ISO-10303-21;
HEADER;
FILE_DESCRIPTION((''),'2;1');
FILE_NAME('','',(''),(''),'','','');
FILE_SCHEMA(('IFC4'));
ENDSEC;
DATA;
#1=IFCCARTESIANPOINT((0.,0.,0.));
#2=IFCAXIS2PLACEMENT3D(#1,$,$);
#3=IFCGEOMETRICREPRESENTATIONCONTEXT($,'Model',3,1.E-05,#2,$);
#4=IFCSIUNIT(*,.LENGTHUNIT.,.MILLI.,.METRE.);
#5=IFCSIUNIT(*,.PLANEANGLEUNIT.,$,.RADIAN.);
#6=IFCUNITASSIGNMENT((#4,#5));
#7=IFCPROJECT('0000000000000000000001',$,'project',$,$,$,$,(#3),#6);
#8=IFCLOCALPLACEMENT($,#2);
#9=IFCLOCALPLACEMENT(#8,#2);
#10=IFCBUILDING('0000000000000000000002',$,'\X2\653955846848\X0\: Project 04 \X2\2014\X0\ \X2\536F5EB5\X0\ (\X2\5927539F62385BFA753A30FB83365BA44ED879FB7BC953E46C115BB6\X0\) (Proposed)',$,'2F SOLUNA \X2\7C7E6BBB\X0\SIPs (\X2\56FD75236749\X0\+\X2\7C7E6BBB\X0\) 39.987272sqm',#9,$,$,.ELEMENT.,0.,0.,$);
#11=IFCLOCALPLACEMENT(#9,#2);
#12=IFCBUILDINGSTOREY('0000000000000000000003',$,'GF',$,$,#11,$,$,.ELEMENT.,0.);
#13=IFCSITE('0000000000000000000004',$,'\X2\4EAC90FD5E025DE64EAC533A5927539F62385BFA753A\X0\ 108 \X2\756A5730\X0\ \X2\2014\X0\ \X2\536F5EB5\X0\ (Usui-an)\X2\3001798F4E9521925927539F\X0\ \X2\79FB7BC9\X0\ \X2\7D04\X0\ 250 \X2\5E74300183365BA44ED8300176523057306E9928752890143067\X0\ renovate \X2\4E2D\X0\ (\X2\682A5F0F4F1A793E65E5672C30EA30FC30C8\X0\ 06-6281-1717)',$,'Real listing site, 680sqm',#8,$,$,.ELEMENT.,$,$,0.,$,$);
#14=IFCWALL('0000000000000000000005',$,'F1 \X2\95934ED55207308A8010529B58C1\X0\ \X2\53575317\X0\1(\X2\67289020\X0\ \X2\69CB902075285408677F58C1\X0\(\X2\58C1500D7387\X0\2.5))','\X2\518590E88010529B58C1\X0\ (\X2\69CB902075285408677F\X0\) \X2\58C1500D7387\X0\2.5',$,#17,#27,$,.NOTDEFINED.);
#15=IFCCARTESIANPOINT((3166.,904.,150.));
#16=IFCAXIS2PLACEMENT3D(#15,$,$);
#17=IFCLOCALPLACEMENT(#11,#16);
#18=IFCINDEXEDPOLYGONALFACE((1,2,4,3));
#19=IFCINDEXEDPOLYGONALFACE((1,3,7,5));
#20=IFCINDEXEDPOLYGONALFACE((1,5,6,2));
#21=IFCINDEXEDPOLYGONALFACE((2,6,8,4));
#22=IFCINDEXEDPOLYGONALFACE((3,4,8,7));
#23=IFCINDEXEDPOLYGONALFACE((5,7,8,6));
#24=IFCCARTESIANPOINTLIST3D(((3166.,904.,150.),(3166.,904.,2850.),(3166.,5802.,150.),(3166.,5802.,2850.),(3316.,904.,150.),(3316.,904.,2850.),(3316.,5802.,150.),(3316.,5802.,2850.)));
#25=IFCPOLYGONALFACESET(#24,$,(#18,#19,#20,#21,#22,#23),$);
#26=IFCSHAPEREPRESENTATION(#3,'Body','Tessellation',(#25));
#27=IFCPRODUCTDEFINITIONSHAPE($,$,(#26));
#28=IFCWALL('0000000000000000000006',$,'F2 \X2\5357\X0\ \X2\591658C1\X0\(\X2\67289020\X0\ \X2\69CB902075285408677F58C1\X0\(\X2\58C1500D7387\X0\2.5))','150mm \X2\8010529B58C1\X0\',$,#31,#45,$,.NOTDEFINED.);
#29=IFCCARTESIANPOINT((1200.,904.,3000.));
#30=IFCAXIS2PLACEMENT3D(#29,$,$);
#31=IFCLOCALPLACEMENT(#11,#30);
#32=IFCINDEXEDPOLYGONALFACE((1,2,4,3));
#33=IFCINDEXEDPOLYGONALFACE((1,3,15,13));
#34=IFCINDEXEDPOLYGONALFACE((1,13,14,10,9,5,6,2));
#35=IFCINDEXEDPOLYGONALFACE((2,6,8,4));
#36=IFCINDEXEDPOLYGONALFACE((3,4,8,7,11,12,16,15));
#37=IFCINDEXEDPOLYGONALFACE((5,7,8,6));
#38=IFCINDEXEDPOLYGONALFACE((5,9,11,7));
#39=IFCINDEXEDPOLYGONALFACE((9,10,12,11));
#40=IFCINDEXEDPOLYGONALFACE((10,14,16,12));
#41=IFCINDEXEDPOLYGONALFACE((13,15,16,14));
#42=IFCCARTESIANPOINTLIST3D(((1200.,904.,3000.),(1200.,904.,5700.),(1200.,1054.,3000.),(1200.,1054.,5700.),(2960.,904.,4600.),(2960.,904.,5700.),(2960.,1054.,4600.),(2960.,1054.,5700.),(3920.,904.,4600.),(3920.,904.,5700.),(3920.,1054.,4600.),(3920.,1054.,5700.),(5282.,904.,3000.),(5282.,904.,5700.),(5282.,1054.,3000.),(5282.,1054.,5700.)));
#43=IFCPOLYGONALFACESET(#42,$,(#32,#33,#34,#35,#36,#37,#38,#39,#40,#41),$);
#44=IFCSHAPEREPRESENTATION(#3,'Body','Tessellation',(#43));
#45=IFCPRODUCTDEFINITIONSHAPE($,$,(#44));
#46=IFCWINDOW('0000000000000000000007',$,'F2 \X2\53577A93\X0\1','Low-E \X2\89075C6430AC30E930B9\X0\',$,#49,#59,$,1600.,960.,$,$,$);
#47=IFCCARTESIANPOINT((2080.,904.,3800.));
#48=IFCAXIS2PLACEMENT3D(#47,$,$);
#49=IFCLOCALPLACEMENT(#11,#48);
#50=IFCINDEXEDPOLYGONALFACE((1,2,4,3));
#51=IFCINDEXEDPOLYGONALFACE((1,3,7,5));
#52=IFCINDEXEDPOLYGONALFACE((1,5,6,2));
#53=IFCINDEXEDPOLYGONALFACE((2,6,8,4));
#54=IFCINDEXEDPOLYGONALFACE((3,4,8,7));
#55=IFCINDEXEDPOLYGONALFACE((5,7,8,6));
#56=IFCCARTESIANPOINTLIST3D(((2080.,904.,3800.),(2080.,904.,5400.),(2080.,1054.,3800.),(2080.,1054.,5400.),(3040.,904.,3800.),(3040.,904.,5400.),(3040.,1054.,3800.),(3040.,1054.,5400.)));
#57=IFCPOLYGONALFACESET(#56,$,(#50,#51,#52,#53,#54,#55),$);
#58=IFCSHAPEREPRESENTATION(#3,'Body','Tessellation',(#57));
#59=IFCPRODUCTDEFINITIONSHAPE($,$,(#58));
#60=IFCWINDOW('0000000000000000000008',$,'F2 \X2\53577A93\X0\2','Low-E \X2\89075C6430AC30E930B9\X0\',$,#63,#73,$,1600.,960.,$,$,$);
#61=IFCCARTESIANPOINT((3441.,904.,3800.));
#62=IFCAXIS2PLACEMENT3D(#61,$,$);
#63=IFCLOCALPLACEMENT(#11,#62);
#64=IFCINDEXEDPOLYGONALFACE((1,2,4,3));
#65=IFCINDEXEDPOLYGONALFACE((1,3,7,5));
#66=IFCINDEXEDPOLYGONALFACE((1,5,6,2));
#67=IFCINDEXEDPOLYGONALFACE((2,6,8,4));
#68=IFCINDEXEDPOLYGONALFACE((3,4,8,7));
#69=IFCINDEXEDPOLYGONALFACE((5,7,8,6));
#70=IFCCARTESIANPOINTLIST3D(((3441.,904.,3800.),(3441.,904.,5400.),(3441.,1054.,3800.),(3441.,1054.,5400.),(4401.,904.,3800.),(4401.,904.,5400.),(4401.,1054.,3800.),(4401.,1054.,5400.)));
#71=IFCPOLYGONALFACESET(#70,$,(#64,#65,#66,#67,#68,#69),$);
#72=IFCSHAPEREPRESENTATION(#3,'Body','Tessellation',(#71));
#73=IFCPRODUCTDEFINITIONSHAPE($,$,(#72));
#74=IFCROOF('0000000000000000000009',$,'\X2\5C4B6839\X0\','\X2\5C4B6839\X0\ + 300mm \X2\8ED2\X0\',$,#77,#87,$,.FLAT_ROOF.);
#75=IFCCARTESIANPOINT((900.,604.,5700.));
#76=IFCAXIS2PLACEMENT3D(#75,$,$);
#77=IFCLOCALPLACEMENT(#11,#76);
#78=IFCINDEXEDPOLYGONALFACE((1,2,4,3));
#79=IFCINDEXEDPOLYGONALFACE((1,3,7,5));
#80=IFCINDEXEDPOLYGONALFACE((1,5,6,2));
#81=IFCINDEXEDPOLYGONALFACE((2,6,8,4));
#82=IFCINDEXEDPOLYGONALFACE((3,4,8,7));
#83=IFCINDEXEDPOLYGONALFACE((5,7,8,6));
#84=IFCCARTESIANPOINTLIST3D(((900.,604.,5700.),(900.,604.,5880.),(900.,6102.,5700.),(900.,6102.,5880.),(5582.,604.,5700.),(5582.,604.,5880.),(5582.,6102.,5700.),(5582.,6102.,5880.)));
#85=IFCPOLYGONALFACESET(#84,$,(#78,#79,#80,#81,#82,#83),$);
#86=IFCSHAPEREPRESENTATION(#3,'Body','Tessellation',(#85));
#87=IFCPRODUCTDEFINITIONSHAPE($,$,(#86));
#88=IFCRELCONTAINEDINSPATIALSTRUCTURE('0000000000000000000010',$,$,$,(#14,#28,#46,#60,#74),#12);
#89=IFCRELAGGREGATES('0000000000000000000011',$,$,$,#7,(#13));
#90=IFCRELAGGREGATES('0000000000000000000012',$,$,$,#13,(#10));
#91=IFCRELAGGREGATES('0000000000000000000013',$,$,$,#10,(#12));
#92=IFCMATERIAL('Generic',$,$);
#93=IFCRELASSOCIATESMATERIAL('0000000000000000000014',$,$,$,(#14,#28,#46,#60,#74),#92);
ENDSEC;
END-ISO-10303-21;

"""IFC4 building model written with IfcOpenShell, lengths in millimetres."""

from ifc_helpers import new_model, si_unit, frame, frame_2d, origin, place, context, project, spatial, rectangle, extrude, material, element, fill, save


model = new_model("IFC4")

# Units and contexts
model_context = context("Model", 3, precision=1e-05, world=origin())
ifc_project = project(units=[si_unit("LENGTHUNIT", "METRE", prefix="MILLI"), si_unit("PLANEANGLEUNIT", "RADIAN")], contexts=[model_context])

# Site, building, storey
site_placement = place(None, origin())
site = spatial("IfcSite", under=ifc_project, at=site_placement, Name="京都市左京区大原戸寺町 108 番地 — 卯庵 (Usui-an)、福井→大原 移築 約 250 年、茶室付、癒しの館用途で renovate 中 (株式会社日本リート 06-6281-1717)", ObjectType="Real listing site, 680sqm", CompositionType="ELEMENT", RefElevation=0.0)
building_placement = place(site_placement, origin())
building = spatial("IfcBuilding", under=site, at=building_placement, Name="改善案: Project 04 — 卯庵 (大原戸寺町・茶室付移築古民家) (Proposed)", ObjectType="2F SOLUNA 籾殻SIPs (国産杉+籾殻) 39.987272sqm", CompositionType="ELEMENT", ElevationOfRefHeight=0.0, ElevationOfTerrain=0.0)
storey_placement = place(building_placement, origin())
storey = spatial("IfcBuildingStorey", under=building, at=storey_placement, Name="GF", CompositionType="ELEMENT", Elevation=0.0)

# Shared definitions
ifc_material_1 = material(Name="Generic")

# Wall
wall_1_placement = place(storey_placement, frame((3166.0, 904.0, 150.0)))
element("IfcWall", 1, at=wall_1_placement, inside=storey, material=ifc_material_1, Name="F1 間仕切り耐力壁 南北1(木造 構造用合板壁(壁倍率2.5))", Description="内部耐力壁 (構造用合板) 壁倍率2.5", PredefinedType="NOTDEFINED", context=model_context, shape_type="SweptSolid", body=[
    extrude(rectangle(XDim=150.0, YDim=4898.0, at=frame_2d((75.0, 2449.0))), frame((3166.0, 904.0, 150.0)), (0.0, 0.0, 1.0), 2700.0),
])

# Wall, openings, windows
wall_2_placement = place(storey_placement, frame((1200.0, 904.0, 3000.0)))
wall_2 = element("IfcWall", 2, at=wall_2_placement, inside=storey, material=ifc_material_1, Name="F2 南 外壁(木造 構造用合板壁(壁倍率2.5))", Description="150mm 耐力壁", PredefinedType="NOTDEFINED", context=model_context, shape_type="SweptSolid", body=[
    extrude(rectangle(XDim=4082.0, YDim=150.0, at=frame_2d((2041.0, 75.0))), frame((1200.0, 904.0, 3000.0)), (0.0, 0.0, 1.0), 2700.0),
])
opening_1_placement = place(storey_placement, frame((2080.0, 904.0, 3800.0)))
opening_1 = element("IfcOpeningElement", 3, at=opening_1_placement, cuts=wall_2, PredefinedType="NOTDEFINED", context=model_context, shape_type="SweptSolid", body=[
    extrude(rectangle(XDim=960.0, YDim=150.0, at=frame_2d((480.0, 75.0))), frame((2080.0, 904.0, 3800.0)), (0.0, 0.0, 1.0), 1600.0),
])
opening_2_placement = place(storey_placement, frame((3441.0, 904.0, 3800.0)))
opening_2 = element("IfcOpeningElement", 4, at=opening_2_placement, cuts=wall_2, PredefinedType="NOTDEFINED", context=model_context, shape_type="SweptSolid", body=[
    extrude(rectangle(XDim=960.0, YDim=150.0, at=frame_2d((480.0, 75.0))), frame((3441.0, 904.0, 3800.0)), (0.0, 0.0, 1.0), 1600.0),
])
window_1_placement = place(storey_placement, frame((2080.0, 904.0, 3800.0)))
window_1 = element("IfcWindow", 5, at=window_1_placement, inside=storey, material=ifc_material_1, Name="F2 南窓1", Description="Low-E 複層ガラス", OverallHeight=1600.0, OverallWidth=960.0, context=model_context, shape_type="SweptSolid", body=[
    extrude(rectangle(XDim=960.0, YDim=150.0, at=frame_2d((480.0, 75.0))), frame((2080.0, 904.0, 3800.0)), (0.0, 0.0, 1.0), 1600.0),
])
fill(opening_1, window_1)
window_2_placement = place(storey_placement, frame((3441.0, 904.0, 3800.0)))
window_2 = element("IfcWindow", 6, at=window_2_placement, inside=storey, material=ifc_material_1, Name="F2 南窓2", Description="Low-E 複層ガラス", OverallHeight=1600.0, OverallWidth=960.0, context=model_context, shape_type="SweptSolid", body=[
    extrude(rectangle(XDim=960.0, YDim=150.0, at=frame_2d((480.0, 75.0))), frame((3441.0, 904.0, 3800.0)), (0.0, 0.0, 1.0), 1600.0),
])
fill(opening_2, window_2)

# Roof
roof_placement = place(storey_placement, frame((900.0, 604.0, 5700.0)))
element("IfcRoof", 7, at=roof_placement, inside=storey, material=ifc_material_1, Name="屋根", Description="屋根 + 300mm 軒", PredefinedType="FLAT_ROOF", context=model_context, shape_type="SweptSolid", body=[
    extrude(rectangle(XDim=4682.0, YDim=5498.0, at=frame_2d((2341.0, 2749.0))), frame((900.0, 604.0, 5700.0)), (0.0, 0.0, 1.0), 180.0),
])

save(model, "model.ifc")
